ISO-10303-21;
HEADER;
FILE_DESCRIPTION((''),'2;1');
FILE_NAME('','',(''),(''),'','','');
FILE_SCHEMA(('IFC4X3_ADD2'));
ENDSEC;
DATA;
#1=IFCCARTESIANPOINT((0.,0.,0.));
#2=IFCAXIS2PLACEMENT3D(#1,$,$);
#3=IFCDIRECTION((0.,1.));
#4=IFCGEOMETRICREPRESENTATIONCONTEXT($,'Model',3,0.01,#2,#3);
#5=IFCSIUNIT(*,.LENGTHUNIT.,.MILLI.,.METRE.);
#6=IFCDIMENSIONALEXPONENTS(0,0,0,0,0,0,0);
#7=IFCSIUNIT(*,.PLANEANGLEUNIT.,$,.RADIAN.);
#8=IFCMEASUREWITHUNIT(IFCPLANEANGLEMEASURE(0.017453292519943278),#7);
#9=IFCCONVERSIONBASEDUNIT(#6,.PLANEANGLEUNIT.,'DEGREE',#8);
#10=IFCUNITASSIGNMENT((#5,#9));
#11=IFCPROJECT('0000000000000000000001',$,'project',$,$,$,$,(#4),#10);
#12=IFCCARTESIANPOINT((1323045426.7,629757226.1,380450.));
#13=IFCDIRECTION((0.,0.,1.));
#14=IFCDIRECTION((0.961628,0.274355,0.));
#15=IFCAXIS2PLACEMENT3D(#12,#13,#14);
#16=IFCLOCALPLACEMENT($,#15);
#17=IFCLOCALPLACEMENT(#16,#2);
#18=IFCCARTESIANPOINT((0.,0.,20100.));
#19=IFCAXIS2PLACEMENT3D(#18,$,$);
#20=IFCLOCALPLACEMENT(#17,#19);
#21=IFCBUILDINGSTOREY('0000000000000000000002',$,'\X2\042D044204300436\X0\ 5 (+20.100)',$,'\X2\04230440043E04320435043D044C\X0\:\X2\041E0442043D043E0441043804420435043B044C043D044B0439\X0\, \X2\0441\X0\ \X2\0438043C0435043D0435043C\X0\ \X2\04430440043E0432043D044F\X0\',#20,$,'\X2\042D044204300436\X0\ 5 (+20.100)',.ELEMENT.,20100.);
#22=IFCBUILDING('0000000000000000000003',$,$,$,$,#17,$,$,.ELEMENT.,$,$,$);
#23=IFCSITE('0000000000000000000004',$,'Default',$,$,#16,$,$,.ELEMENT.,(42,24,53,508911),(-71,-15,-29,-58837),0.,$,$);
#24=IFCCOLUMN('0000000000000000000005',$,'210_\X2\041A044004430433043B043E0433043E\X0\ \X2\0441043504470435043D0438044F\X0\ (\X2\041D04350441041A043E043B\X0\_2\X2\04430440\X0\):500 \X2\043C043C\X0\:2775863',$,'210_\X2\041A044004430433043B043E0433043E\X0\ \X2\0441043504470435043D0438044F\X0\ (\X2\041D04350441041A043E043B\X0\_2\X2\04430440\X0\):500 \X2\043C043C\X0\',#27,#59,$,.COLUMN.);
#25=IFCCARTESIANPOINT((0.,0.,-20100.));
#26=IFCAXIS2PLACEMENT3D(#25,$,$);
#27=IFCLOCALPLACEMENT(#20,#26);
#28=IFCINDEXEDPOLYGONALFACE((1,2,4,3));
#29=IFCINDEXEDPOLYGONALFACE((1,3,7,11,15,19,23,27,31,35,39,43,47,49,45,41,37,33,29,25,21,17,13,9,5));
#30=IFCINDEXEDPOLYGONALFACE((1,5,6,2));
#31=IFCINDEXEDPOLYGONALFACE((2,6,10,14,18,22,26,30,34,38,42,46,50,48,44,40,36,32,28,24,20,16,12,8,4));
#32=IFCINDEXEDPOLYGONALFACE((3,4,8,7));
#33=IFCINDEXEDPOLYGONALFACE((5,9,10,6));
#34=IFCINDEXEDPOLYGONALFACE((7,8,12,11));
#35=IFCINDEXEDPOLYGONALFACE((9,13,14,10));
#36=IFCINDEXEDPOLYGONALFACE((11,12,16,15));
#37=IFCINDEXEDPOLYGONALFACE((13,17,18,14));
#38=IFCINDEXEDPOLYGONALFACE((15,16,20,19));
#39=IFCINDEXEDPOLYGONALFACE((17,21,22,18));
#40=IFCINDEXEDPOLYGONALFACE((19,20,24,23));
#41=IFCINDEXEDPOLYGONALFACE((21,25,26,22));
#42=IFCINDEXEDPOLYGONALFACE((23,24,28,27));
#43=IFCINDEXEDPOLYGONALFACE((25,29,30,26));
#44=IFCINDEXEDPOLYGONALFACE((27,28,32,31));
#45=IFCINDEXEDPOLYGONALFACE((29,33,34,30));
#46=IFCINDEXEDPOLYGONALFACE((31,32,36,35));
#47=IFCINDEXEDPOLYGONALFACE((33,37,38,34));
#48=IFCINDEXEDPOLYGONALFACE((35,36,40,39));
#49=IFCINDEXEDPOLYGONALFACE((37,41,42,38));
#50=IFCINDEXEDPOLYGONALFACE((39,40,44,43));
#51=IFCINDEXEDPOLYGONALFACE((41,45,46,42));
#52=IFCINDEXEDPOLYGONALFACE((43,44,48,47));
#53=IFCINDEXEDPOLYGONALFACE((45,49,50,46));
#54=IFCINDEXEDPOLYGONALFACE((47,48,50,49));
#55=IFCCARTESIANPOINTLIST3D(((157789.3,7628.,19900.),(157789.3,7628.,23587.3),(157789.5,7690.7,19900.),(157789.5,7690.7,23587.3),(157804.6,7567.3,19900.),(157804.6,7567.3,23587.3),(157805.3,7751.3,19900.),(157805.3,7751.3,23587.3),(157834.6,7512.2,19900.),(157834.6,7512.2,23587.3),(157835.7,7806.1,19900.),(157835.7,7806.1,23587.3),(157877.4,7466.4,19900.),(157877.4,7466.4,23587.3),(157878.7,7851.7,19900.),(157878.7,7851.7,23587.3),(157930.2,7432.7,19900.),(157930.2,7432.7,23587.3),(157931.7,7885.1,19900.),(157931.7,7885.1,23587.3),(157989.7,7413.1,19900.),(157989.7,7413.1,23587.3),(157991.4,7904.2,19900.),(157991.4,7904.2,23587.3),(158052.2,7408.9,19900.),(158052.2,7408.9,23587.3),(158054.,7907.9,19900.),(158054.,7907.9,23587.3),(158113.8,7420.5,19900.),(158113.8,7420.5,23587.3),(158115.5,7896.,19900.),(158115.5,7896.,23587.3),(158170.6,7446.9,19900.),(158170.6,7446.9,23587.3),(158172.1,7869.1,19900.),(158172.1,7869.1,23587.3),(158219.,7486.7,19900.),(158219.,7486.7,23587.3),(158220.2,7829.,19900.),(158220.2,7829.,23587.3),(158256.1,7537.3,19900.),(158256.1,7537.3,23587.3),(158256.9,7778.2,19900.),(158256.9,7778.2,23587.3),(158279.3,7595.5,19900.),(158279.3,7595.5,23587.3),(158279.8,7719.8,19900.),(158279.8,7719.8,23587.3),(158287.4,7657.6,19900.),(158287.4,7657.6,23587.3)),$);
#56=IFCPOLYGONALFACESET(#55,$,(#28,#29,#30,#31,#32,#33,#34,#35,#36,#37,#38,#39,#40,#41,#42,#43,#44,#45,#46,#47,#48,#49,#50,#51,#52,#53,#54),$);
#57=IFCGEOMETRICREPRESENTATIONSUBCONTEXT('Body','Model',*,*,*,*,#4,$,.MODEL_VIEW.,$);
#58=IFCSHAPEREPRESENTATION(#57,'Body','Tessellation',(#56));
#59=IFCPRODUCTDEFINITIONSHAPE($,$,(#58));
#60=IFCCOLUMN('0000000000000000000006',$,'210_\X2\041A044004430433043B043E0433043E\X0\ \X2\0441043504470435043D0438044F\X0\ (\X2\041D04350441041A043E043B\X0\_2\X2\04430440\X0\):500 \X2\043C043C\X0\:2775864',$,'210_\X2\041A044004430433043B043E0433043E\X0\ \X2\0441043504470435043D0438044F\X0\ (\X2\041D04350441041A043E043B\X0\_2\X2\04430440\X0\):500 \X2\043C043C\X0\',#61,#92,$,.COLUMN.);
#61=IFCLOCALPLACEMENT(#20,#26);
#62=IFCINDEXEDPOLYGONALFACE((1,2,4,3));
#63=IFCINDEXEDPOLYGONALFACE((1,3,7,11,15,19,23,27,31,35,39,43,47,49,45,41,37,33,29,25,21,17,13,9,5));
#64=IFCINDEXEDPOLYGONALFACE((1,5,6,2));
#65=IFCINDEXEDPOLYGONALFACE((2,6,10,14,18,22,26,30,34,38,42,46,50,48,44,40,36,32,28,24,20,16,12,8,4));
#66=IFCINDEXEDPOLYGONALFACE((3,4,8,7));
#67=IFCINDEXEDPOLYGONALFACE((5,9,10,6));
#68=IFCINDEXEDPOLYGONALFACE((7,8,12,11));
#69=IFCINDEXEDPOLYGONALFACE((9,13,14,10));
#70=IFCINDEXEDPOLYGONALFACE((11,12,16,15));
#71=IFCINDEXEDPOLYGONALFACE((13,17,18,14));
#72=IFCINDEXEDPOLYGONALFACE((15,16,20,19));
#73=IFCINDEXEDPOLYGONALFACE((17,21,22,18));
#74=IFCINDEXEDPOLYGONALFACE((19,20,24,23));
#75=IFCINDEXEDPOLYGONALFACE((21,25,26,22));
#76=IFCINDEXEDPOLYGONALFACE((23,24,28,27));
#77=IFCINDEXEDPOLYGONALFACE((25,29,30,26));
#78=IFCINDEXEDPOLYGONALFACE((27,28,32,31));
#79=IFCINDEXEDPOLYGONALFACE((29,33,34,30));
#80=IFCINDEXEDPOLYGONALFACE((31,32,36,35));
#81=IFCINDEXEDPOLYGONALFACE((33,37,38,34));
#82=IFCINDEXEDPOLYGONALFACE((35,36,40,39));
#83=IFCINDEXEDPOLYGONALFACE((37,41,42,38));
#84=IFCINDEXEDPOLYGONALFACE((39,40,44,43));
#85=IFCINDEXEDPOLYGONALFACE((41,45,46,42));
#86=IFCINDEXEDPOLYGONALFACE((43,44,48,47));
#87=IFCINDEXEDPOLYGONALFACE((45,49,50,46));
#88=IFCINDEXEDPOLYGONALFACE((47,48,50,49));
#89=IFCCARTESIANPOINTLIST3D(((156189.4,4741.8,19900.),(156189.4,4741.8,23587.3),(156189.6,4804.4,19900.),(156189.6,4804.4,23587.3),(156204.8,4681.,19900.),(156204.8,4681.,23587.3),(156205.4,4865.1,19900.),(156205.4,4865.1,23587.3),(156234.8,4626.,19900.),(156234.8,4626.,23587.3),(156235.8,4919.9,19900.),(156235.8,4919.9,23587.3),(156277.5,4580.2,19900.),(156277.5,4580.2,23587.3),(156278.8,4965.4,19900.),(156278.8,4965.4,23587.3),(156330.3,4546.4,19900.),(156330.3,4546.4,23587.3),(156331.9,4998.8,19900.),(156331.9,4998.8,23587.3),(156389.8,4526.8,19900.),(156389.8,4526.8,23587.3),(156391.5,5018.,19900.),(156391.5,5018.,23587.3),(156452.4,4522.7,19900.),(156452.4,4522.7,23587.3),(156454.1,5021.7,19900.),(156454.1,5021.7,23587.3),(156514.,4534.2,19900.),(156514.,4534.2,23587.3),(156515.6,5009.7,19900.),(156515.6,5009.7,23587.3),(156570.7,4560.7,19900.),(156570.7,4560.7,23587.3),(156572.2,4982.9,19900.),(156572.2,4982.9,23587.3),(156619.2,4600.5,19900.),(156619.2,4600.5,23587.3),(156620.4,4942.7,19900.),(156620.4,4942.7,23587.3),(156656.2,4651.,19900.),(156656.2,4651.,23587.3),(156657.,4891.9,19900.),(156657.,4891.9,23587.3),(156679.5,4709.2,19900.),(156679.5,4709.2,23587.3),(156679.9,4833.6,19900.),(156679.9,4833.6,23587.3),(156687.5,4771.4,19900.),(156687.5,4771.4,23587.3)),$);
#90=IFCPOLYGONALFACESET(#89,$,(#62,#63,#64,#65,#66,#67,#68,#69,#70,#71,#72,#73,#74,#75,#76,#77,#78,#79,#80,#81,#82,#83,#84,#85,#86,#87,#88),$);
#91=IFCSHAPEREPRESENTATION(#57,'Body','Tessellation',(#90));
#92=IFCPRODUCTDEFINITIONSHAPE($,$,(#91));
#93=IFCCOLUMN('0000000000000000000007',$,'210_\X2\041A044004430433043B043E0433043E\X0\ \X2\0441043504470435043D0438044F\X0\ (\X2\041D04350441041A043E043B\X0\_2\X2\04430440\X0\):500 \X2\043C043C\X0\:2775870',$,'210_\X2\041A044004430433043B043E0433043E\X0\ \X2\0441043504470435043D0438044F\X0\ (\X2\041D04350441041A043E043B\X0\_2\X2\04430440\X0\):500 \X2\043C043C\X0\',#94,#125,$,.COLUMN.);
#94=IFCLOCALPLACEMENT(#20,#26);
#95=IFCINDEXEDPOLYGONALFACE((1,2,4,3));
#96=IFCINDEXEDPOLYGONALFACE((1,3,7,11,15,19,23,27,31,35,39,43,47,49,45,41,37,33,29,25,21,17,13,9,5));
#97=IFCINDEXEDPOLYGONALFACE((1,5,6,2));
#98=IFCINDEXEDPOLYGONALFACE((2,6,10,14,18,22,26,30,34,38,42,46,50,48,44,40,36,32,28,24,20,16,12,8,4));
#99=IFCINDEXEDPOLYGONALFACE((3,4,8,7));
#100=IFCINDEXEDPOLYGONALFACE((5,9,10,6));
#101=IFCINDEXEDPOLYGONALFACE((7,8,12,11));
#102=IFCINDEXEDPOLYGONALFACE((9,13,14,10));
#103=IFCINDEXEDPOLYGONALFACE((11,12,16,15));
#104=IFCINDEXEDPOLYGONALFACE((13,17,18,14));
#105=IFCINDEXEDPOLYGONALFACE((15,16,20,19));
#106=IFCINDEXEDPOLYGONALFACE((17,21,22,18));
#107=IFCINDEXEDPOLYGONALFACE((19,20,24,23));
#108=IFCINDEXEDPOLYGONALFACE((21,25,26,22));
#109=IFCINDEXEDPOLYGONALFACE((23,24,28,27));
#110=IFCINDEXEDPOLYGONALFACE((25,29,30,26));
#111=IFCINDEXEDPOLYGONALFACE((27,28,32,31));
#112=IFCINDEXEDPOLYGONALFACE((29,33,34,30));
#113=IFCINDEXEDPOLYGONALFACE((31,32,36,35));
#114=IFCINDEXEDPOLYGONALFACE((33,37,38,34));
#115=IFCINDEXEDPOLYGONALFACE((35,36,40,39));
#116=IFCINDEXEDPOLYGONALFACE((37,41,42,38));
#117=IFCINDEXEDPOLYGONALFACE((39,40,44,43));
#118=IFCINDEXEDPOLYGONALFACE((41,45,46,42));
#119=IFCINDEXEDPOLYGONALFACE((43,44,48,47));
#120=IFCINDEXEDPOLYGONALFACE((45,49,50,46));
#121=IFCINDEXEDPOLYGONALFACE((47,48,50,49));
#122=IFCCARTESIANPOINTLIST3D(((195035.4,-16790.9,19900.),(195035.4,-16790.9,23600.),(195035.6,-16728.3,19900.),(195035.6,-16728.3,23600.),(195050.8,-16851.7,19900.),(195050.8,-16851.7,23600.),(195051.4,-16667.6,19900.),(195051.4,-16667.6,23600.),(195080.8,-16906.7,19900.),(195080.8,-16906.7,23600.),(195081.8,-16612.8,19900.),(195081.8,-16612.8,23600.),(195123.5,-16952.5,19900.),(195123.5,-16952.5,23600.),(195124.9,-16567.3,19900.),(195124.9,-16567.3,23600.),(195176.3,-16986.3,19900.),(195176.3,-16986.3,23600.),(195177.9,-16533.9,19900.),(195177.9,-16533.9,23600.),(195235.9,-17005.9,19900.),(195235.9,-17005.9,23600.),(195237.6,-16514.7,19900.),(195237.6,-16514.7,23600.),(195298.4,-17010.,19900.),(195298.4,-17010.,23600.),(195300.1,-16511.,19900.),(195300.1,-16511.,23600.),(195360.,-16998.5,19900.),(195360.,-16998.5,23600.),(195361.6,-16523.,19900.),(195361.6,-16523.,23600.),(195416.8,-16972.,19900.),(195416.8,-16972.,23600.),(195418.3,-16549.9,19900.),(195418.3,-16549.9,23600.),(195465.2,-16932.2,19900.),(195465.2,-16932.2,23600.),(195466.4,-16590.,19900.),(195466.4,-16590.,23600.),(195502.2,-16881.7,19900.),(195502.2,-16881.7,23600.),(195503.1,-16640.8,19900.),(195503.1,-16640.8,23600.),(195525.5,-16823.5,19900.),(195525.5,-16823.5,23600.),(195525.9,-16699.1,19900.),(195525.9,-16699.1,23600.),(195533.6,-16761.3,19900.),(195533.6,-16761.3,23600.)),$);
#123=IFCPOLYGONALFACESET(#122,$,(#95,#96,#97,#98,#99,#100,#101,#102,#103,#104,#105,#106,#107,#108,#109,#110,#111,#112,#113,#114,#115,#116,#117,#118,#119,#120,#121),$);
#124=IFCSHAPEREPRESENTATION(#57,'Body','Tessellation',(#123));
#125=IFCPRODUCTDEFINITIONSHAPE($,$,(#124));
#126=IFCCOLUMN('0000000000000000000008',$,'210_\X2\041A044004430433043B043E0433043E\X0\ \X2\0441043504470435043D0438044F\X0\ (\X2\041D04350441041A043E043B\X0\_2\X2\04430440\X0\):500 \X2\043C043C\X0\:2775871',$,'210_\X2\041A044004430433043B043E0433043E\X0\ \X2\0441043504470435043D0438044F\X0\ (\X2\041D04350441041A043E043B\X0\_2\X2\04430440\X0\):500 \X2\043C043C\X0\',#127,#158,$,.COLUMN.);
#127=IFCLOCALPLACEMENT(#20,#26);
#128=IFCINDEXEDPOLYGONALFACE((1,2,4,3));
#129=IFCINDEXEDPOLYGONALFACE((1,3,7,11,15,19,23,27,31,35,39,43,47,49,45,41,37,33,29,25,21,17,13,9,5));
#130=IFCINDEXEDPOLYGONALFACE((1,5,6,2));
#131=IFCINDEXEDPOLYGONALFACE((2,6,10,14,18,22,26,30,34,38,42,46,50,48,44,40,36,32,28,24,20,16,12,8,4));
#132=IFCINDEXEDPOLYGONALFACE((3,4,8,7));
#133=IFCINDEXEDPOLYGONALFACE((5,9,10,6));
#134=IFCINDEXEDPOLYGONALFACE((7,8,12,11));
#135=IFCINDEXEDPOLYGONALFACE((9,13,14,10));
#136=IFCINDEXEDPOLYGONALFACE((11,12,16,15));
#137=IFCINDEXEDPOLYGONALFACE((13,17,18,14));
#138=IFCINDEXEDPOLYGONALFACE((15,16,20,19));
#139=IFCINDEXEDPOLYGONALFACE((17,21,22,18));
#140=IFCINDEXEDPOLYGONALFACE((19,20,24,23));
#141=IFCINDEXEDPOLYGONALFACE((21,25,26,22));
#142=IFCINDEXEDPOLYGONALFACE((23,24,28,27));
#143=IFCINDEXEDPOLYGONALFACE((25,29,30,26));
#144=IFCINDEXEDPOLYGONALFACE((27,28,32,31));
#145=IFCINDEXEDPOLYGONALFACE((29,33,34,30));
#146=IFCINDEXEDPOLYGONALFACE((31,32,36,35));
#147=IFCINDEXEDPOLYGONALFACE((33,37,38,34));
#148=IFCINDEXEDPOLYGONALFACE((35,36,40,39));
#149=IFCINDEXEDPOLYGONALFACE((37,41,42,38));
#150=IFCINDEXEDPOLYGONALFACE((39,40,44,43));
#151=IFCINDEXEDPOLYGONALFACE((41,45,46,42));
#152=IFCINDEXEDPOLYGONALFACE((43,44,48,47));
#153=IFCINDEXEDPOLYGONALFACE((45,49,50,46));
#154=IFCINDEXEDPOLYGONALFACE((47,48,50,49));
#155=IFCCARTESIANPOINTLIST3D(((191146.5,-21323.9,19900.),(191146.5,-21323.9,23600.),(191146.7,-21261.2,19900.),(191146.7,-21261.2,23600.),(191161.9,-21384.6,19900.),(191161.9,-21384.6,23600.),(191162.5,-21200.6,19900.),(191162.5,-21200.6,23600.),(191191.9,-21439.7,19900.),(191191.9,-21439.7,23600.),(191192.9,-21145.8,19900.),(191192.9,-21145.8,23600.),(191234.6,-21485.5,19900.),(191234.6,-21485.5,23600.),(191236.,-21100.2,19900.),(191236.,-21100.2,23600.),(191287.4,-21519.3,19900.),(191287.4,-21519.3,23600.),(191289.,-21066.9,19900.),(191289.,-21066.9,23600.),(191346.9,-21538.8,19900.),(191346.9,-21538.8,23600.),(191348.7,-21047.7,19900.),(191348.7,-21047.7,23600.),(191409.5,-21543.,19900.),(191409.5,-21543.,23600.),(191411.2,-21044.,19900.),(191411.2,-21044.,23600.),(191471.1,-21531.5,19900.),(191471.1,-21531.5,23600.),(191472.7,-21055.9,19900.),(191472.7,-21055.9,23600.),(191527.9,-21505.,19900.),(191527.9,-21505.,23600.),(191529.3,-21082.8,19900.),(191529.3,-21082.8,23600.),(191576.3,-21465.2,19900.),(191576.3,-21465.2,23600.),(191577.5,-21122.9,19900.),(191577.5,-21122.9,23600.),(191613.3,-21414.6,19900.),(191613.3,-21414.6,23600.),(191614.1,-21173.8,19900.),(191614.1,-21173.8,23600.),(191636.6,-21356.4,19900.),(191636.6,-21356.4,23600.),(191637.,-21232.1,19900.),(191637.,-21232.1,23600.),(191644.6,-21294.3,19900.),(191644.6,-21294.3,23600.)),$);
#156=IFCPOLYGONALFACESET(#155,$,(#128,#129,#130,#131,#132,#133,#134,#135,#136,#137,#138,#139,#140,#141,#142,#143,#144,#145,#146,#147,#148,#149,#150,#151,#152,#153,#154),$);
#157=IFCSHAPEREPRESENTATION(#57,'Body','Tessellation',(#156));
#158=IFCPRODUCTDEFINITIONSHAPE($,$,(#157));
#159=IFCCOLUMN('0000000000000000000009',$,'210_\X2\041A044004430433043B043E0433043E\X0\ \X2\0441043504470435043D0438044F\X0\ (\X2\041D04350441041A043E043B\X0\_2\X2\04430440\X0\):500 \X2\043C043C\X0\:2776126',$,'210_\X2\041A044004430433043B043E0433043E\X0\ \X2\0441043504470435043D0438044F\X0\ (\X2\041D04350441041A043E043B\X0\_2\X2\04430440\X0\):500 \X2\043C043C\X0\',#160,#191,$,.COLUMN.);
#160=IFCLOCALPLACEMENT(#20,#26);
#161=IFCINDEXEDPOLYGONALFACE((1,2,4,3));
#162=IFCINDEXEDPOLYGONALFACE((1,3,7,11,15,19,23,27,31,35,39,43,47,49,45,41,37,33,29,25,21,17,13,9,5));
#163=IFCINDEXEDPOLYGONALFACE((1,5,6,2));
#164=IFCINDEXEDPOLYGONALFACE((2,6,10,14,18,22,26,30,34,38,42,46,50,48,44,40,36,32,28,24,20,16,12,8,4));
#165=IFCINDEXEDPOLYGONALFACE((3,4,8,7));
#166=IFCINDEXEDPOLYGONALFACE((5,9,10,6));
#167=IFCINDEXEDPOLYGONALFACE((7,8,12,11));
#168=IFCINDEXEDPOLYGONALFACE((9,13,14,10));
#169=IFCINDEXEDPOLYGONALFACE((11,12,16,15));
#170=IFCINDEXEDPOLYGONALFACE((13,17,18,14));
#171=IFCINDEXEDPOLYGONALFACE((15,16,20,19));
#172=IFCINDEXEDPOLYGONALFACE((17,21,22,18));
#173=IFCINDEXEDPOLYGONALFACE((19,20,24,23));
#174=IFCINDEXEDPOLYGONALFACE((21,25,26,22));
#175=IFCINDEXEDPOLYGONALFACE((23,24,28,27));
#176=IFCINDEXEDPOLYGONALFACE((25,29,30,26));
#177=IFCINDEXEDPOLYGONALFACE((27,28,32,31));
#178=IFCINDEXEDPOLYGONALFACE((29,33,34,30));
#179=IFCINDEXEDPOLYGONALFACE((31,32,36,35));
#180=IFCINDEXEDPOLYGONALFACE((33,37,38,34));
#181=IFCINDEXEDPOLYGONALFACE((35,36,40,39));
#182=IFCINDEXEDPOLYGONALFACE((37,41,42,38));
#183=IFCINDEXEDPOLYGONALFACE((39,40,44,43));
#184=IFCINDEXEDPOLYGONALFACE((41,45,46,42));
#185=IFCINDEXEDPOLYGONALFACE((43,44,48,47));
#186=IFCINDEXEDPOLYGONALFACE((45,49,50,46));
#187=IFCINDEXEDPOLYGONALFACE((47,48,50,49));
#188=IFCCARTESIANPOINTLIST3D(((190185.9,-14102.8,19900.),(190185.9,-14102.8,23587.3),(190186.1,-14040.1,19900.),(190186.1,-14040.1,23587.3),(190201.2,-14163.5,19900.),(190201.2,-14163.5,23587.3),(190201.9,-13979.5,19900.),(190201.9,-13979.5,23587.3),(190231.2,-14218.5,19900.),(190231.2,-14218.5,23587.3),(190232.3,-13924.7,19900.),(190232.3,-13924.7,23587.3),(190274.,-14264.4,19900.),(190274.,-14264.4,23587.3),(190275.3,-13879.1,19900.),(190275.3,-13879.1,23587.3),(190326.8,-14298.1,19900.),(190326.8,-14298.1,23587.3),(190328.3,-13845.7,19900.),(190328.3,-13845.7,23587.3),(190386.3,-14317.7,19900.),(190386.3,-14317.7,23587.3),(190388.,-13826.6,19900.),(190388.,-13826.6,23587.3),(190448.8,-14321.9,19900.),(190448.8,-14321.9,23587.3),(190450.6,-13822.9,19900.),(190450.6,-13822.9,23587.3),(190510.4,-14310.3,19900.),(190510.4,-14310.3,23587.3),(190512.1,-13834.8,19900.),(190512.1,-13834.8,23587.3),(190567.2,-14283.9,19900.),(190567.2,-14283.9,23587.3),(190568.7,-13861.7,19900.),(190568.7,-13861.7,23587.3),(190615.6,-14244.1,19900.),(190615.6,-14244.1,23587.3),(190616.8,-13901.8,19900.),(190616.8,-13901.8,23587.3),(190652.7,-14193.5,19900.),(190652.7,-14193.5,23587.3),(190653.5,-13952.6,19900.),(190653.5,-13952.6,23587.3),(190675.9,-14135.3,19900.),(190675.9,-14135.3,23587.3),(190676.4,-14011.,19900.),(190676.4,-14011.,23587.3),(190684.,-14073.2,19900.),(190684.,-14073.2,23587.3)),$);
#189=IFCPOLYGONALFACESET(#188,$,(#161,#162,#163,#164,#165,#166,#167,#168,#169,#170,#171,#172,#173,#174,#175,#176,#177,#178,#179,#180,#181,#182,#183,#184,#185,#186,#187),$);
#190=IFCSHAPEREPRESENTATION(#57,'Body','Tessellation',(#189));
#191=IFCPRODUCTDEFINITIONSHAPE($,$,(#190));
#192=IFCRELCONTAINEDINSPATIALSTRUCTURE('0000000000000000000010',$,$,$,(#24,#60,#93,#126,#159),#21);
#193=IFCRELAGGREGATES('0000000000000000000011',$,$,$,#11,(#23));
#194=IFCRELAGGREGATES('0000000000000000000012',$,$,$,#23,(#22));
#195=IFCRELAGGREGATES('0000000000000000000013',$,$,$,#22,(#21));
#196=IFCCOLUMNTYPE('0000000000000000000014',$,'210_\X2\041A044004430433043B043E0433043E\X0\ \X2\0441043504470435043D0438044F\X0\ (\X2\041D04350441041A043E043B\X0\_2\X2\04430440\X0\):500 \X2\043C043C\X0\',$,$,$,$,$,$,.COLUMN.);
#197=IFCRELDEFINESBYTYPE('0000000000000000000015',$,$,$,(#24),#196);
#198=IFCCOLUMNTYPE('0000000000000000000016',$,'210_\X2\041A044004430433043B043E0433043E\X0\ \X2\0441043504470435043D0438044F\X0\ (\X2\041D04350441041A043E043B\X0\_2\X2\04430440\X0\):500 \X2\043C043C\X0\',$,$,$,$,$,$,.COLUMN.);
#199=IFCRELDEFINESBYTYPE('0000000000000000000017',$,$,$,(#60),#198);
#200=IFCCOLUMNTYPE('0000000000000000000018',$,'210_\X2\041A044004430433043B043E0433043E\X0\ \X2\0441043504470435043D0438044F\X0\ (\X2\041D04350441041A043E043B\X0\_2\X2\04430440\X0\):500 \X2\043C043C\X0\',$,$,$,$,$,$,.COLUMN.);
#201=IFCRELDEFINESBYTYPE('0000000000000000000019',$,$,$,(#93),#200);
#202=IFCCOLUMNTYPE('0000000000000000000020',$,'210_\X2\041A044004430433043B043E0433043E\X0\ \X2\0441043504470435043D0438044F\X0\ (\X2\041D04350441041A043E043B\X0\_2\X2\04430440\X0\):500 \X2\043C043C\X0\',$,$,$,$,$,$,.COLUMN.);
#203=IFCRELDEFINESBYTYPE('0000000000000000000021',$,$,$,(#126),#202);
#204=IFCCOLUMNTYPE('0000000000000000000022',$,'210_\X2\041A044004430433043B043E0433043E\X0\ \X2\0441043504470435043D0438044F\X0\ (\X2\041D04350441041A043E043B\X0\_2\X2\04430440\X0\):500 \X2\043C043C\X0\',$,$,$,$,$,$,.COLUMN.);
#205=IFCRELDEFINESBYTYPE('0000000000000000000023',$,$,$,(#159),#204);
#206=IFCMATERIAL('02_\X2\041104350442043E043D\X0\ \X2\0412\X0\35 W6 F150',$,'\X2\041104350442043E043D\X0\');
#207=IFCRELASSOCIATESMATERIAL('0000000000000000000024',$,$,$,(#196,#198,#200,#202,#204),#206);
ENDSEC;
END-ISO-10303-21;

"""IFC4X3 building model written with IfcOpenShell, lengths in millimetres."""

from ifc_helpers import new_model, entity, si_unit, converted_unit, direction, frame, frame_2d, origin, origin_2d_with_axis, place, context, subcontext, project, spatial, circle, extrude, source, transform, mapped, material, material_profile, profile_set, type_object, type_shapes, element, save


model = new_model("IFC4X3")

# Units and contexts
model_context = context("Model", 3, precision=0.01, world=origin(), true_north=direction((0.0, 1.0)))
body_context = subcontext(model_context, "Body", "Model", "MODEL_VIEW")
ifc_project = project(units=[si_unit("LENGTHUNIT", "METRE", prefix="MILLI"), converted_unit("PLANEANGLEUNIT", "DEGREE", entity("IfcPlaneAngleMeasure", 0.017453292519943278), si_unit("PLANEANGLEUNIT", "RADIAN"), dimensions=[0, 0, 0, 0, 0, 0, 0])], contexts=[model_context])

# Site, building, storey
site_placement = place(None, frame((1323045426.7, 629757226.1, 380450.0), z_axis=(0.0, 0.0, 1.0), x_axis=(0.961628, 0.274355, 0.0)))
site = spatial("IfcSite", under=ifc_project, at=site_placement, Name="Default", CompositionType="ELEMENT", RefLatitude=(42, 24, 53, 508911), RefLongitude=(-71, -15, -29, -58837), RefElevation=0.0)
building_placement = place(site_placement, origin())
building = spatial("IfcBuilding", under=site, at=building_placement, CompositionType="ELEMENT")
storey_placement = place(building_placement, frame((0.0, 0.0, 20100.0)))
storey = spatial("IfcBuildingStorey", under=building, at=storey_placement, Name="Этаж 5 (+20.100)", ObjectType="Уровень:Относительный, с именем уровня", LongName="Этаж 5 (+20.100)", CompositionType="ELEMENT", Elevation=20100.0)

# Columns
ifc_material_1 = material(Name="02_Бетон В35 W6 F150", Category="Бетон")
ifc_material_profile_1 = material_profile(ifc_material_1, circle(Radius=250.0, at=frame_2d((0.0, 0.0), x_axis=(1.0, 0.0))), Name="500 мм")
ifc_profile_set_1 = profile_set([ifc_material_profile_1], Name="500 мм")
column_type_1 = type_object("IfcColumnType", Name="210_Круглого сечения (НесКол_2ур):500 мм", PredefinedType="COLUMN", material=ifc_profile_set_1)
shared_shape_1 = source(origin(), body_context, "Body", "SweptSolid", [
    extrude(circle(Radius=250.0, at=frame_2d((0.0, 0.0), x_axis=(1.0, 0.0))), frame((158037.4, 7658.5, 19900.0), z_axis=(0.0, 0.0, 1.0), x_axis=(0.87462, -0.48481, 0.0)), (0.0, 0.0, 1.0), 3687.3),
])
type_shapes(column_type_1, [shared_shape_1])
column_1_placement = place(storey_placement, frame((0.0, 0.0, -20100.0)))
element("IfcColumn", 1, at=column_1_placement, inside=storey, type_object=column_type_1, Name="210_Круглого сечения (НесКол_2ур):500 мм:2775863", ObjectType="210_Круглого сечения (НесКол_2ур):500 мм", PredefinedType="COLUMN", context=body_context, shape_type="MappedRepresentation", body=[
    mapped(shared_shape_1, transform((0.0, 0.0, 0.0), scale=1.0)),
])
column_type_2 = type_object("IfcColumnType", Name="210_Круглого сечения (НесКол_2ур):500 мм", PredefinedType="COLUMN", material=ifc_profile_set_1)
shared_shape_2 = source(origin(), body_context, "Body", "SweptSolid", [
    extrude(circle(Radius=250.0, at=frame_2d((0.0, 0.0), x_axis=(1.0, 0.0))), frame((156437.5, 4772.2, 19900.0), z_axis=(0.0, 0.0, 1.0), x_axis=(0.87462, -0.48481, 0.0)), (0.0, 0.0, 1.0), 3687.3),
])
type_shapes(column_type_2, [shared_shape_2])
column_2_placement = place(storey_placement, frame((0.0, 0.0, -20100.0)))
element("IfcColumn", 2, at=column_2_placement, inside=storey, type_object=column_type_2, Name="210_Круглого сечения (НесКол_2ур):500 мм:2775864", ObjectType="210_Круглого сечения (НесКол_2ур):500 мм", PredefinedType="COLUMN", context=body_context, shape_type="MappedRepresentation", body=[
    mapped(shared_shape_2, transform((0.0, 0.0, 0.0), scale=1.0)),
])
column_type_3 = type_object("IfcColumnType", Name="210_Круглого сечения (НесКол_2ур):500 мм", PredefinedType="COLUMN", material=ifc_profile_set_1)
shared_shape_3 = source(origin(), body_context, "Body", "SweptSolid", [
    extrude(circle(Radius=250.0, at=frame_2d((0.0, 0.0), x_axis=(1.0, 0.0))), frame((195283.6, -16760.5, 19900.0), z_axis=(0.0, 0.0, 1.0), x_axis=(0.87462, -0.48481, 0.0)), (0.0, 0.0, 1.0), 3700.0),
])
type_shapes(column_type_3, [shared_shape_3])
column_3_placement = place(storey_placement, frame((0.0, 0.0, -20100.0)))
element("IfcColumn", 3, at=column_3_placement, inside=storey, type_object=column_type_3, Name="210_Круглого сечения (НесКол_2ур):500 мм:2775870", ObjectType="210_Круглого сечения (НесКол_2ур):500 мм", PredefinedType="COLUMN", context=body_context, shape_type="MappedRepresentation", body=[
    mapped(shared_shape_3, transform((0.0, 0.0, 0.0), scale=1.0)),
])
column_type_4 = type_object("IfcColumnType", Name="210_Круглого сечения (НесКол_2ур):500 мм", PredefinedType="COLUMN", material=ifc_profile_set_1)
shared_shape_4 = source(origin(), body_context, "Body", "SweptSolid", [
    extrude(circle(Radius=250.0, at=origin_2d_with_axis()), frame((191394.6, -21293.4, 19900.0), z_axis=(0.0, 0.0, 1.0), x_axis=(0.87462, -0.48481, 0.0)), (0.0, 0.0, 1.0), 3700.0),
])
type_shapes(column_type_4, [shared_shape_4])
column_4_placement = place(storey_placement, frame((0.0, 0.0, -20100.0)))
element("IfcColumn", 4, at=column_4_placement, inside=storey, type_object=column_type_4, Name="210_Круглого сечения (НесКол_2ур):500 мм:2775871", ObjectType="210_Круглого сечения (НесКол_2ур):500 мм", PredefinedType="COLUMN", context=body_context, shape_type="MappedRepresentation", body=[
    mapped(shared_shape_4, transform((0.0, 0.0, 0.0), scale=1.0)),
])
column_type_5 = type_object("IfcColumnType", Name="210_Круглого сечения (НесКол_2ур):500 мм", PredefinedType="COLUMN", material=ifc_profile_set_1)
shared_shape_5 = source(origin(), body_context, "Body", "SweptSolid", [
    extrude(circle(Radius=250.0, at=frame_2d((0.0, 0.0), x_axis=(1.0, 0.0))), frame((190434.0, -14072.3, 19900.0), z_axis=(0.0, 0.0, 1.0), x_axis=(0.87462, -0.48481, 0.0)), (0.0, 0.0, 1.0), 3687.3),
])
type_shapes(column_type_5, [shared_shape_5])
column_5_placement = place(storey_placement, frame((0.0, 0.0, -20100.0)))
element("IfcColumn", 5, at=column_5_placement, inside=storey, type_object=column_type_5, Name="210_Круглого сечения (НесКол_2ур):500 мм:2776126", ObjectType="210_Круглого сечения (НесКол_2ур):500 мм", PredefinedType="COLUMN", context=body_context, shape_type="MappedRepresentation", body=[
    mapped(shared_shape_5, transform((0.0, 0.0, 0.0), scale=1.0)),
])

save(model, "model.ifc")
